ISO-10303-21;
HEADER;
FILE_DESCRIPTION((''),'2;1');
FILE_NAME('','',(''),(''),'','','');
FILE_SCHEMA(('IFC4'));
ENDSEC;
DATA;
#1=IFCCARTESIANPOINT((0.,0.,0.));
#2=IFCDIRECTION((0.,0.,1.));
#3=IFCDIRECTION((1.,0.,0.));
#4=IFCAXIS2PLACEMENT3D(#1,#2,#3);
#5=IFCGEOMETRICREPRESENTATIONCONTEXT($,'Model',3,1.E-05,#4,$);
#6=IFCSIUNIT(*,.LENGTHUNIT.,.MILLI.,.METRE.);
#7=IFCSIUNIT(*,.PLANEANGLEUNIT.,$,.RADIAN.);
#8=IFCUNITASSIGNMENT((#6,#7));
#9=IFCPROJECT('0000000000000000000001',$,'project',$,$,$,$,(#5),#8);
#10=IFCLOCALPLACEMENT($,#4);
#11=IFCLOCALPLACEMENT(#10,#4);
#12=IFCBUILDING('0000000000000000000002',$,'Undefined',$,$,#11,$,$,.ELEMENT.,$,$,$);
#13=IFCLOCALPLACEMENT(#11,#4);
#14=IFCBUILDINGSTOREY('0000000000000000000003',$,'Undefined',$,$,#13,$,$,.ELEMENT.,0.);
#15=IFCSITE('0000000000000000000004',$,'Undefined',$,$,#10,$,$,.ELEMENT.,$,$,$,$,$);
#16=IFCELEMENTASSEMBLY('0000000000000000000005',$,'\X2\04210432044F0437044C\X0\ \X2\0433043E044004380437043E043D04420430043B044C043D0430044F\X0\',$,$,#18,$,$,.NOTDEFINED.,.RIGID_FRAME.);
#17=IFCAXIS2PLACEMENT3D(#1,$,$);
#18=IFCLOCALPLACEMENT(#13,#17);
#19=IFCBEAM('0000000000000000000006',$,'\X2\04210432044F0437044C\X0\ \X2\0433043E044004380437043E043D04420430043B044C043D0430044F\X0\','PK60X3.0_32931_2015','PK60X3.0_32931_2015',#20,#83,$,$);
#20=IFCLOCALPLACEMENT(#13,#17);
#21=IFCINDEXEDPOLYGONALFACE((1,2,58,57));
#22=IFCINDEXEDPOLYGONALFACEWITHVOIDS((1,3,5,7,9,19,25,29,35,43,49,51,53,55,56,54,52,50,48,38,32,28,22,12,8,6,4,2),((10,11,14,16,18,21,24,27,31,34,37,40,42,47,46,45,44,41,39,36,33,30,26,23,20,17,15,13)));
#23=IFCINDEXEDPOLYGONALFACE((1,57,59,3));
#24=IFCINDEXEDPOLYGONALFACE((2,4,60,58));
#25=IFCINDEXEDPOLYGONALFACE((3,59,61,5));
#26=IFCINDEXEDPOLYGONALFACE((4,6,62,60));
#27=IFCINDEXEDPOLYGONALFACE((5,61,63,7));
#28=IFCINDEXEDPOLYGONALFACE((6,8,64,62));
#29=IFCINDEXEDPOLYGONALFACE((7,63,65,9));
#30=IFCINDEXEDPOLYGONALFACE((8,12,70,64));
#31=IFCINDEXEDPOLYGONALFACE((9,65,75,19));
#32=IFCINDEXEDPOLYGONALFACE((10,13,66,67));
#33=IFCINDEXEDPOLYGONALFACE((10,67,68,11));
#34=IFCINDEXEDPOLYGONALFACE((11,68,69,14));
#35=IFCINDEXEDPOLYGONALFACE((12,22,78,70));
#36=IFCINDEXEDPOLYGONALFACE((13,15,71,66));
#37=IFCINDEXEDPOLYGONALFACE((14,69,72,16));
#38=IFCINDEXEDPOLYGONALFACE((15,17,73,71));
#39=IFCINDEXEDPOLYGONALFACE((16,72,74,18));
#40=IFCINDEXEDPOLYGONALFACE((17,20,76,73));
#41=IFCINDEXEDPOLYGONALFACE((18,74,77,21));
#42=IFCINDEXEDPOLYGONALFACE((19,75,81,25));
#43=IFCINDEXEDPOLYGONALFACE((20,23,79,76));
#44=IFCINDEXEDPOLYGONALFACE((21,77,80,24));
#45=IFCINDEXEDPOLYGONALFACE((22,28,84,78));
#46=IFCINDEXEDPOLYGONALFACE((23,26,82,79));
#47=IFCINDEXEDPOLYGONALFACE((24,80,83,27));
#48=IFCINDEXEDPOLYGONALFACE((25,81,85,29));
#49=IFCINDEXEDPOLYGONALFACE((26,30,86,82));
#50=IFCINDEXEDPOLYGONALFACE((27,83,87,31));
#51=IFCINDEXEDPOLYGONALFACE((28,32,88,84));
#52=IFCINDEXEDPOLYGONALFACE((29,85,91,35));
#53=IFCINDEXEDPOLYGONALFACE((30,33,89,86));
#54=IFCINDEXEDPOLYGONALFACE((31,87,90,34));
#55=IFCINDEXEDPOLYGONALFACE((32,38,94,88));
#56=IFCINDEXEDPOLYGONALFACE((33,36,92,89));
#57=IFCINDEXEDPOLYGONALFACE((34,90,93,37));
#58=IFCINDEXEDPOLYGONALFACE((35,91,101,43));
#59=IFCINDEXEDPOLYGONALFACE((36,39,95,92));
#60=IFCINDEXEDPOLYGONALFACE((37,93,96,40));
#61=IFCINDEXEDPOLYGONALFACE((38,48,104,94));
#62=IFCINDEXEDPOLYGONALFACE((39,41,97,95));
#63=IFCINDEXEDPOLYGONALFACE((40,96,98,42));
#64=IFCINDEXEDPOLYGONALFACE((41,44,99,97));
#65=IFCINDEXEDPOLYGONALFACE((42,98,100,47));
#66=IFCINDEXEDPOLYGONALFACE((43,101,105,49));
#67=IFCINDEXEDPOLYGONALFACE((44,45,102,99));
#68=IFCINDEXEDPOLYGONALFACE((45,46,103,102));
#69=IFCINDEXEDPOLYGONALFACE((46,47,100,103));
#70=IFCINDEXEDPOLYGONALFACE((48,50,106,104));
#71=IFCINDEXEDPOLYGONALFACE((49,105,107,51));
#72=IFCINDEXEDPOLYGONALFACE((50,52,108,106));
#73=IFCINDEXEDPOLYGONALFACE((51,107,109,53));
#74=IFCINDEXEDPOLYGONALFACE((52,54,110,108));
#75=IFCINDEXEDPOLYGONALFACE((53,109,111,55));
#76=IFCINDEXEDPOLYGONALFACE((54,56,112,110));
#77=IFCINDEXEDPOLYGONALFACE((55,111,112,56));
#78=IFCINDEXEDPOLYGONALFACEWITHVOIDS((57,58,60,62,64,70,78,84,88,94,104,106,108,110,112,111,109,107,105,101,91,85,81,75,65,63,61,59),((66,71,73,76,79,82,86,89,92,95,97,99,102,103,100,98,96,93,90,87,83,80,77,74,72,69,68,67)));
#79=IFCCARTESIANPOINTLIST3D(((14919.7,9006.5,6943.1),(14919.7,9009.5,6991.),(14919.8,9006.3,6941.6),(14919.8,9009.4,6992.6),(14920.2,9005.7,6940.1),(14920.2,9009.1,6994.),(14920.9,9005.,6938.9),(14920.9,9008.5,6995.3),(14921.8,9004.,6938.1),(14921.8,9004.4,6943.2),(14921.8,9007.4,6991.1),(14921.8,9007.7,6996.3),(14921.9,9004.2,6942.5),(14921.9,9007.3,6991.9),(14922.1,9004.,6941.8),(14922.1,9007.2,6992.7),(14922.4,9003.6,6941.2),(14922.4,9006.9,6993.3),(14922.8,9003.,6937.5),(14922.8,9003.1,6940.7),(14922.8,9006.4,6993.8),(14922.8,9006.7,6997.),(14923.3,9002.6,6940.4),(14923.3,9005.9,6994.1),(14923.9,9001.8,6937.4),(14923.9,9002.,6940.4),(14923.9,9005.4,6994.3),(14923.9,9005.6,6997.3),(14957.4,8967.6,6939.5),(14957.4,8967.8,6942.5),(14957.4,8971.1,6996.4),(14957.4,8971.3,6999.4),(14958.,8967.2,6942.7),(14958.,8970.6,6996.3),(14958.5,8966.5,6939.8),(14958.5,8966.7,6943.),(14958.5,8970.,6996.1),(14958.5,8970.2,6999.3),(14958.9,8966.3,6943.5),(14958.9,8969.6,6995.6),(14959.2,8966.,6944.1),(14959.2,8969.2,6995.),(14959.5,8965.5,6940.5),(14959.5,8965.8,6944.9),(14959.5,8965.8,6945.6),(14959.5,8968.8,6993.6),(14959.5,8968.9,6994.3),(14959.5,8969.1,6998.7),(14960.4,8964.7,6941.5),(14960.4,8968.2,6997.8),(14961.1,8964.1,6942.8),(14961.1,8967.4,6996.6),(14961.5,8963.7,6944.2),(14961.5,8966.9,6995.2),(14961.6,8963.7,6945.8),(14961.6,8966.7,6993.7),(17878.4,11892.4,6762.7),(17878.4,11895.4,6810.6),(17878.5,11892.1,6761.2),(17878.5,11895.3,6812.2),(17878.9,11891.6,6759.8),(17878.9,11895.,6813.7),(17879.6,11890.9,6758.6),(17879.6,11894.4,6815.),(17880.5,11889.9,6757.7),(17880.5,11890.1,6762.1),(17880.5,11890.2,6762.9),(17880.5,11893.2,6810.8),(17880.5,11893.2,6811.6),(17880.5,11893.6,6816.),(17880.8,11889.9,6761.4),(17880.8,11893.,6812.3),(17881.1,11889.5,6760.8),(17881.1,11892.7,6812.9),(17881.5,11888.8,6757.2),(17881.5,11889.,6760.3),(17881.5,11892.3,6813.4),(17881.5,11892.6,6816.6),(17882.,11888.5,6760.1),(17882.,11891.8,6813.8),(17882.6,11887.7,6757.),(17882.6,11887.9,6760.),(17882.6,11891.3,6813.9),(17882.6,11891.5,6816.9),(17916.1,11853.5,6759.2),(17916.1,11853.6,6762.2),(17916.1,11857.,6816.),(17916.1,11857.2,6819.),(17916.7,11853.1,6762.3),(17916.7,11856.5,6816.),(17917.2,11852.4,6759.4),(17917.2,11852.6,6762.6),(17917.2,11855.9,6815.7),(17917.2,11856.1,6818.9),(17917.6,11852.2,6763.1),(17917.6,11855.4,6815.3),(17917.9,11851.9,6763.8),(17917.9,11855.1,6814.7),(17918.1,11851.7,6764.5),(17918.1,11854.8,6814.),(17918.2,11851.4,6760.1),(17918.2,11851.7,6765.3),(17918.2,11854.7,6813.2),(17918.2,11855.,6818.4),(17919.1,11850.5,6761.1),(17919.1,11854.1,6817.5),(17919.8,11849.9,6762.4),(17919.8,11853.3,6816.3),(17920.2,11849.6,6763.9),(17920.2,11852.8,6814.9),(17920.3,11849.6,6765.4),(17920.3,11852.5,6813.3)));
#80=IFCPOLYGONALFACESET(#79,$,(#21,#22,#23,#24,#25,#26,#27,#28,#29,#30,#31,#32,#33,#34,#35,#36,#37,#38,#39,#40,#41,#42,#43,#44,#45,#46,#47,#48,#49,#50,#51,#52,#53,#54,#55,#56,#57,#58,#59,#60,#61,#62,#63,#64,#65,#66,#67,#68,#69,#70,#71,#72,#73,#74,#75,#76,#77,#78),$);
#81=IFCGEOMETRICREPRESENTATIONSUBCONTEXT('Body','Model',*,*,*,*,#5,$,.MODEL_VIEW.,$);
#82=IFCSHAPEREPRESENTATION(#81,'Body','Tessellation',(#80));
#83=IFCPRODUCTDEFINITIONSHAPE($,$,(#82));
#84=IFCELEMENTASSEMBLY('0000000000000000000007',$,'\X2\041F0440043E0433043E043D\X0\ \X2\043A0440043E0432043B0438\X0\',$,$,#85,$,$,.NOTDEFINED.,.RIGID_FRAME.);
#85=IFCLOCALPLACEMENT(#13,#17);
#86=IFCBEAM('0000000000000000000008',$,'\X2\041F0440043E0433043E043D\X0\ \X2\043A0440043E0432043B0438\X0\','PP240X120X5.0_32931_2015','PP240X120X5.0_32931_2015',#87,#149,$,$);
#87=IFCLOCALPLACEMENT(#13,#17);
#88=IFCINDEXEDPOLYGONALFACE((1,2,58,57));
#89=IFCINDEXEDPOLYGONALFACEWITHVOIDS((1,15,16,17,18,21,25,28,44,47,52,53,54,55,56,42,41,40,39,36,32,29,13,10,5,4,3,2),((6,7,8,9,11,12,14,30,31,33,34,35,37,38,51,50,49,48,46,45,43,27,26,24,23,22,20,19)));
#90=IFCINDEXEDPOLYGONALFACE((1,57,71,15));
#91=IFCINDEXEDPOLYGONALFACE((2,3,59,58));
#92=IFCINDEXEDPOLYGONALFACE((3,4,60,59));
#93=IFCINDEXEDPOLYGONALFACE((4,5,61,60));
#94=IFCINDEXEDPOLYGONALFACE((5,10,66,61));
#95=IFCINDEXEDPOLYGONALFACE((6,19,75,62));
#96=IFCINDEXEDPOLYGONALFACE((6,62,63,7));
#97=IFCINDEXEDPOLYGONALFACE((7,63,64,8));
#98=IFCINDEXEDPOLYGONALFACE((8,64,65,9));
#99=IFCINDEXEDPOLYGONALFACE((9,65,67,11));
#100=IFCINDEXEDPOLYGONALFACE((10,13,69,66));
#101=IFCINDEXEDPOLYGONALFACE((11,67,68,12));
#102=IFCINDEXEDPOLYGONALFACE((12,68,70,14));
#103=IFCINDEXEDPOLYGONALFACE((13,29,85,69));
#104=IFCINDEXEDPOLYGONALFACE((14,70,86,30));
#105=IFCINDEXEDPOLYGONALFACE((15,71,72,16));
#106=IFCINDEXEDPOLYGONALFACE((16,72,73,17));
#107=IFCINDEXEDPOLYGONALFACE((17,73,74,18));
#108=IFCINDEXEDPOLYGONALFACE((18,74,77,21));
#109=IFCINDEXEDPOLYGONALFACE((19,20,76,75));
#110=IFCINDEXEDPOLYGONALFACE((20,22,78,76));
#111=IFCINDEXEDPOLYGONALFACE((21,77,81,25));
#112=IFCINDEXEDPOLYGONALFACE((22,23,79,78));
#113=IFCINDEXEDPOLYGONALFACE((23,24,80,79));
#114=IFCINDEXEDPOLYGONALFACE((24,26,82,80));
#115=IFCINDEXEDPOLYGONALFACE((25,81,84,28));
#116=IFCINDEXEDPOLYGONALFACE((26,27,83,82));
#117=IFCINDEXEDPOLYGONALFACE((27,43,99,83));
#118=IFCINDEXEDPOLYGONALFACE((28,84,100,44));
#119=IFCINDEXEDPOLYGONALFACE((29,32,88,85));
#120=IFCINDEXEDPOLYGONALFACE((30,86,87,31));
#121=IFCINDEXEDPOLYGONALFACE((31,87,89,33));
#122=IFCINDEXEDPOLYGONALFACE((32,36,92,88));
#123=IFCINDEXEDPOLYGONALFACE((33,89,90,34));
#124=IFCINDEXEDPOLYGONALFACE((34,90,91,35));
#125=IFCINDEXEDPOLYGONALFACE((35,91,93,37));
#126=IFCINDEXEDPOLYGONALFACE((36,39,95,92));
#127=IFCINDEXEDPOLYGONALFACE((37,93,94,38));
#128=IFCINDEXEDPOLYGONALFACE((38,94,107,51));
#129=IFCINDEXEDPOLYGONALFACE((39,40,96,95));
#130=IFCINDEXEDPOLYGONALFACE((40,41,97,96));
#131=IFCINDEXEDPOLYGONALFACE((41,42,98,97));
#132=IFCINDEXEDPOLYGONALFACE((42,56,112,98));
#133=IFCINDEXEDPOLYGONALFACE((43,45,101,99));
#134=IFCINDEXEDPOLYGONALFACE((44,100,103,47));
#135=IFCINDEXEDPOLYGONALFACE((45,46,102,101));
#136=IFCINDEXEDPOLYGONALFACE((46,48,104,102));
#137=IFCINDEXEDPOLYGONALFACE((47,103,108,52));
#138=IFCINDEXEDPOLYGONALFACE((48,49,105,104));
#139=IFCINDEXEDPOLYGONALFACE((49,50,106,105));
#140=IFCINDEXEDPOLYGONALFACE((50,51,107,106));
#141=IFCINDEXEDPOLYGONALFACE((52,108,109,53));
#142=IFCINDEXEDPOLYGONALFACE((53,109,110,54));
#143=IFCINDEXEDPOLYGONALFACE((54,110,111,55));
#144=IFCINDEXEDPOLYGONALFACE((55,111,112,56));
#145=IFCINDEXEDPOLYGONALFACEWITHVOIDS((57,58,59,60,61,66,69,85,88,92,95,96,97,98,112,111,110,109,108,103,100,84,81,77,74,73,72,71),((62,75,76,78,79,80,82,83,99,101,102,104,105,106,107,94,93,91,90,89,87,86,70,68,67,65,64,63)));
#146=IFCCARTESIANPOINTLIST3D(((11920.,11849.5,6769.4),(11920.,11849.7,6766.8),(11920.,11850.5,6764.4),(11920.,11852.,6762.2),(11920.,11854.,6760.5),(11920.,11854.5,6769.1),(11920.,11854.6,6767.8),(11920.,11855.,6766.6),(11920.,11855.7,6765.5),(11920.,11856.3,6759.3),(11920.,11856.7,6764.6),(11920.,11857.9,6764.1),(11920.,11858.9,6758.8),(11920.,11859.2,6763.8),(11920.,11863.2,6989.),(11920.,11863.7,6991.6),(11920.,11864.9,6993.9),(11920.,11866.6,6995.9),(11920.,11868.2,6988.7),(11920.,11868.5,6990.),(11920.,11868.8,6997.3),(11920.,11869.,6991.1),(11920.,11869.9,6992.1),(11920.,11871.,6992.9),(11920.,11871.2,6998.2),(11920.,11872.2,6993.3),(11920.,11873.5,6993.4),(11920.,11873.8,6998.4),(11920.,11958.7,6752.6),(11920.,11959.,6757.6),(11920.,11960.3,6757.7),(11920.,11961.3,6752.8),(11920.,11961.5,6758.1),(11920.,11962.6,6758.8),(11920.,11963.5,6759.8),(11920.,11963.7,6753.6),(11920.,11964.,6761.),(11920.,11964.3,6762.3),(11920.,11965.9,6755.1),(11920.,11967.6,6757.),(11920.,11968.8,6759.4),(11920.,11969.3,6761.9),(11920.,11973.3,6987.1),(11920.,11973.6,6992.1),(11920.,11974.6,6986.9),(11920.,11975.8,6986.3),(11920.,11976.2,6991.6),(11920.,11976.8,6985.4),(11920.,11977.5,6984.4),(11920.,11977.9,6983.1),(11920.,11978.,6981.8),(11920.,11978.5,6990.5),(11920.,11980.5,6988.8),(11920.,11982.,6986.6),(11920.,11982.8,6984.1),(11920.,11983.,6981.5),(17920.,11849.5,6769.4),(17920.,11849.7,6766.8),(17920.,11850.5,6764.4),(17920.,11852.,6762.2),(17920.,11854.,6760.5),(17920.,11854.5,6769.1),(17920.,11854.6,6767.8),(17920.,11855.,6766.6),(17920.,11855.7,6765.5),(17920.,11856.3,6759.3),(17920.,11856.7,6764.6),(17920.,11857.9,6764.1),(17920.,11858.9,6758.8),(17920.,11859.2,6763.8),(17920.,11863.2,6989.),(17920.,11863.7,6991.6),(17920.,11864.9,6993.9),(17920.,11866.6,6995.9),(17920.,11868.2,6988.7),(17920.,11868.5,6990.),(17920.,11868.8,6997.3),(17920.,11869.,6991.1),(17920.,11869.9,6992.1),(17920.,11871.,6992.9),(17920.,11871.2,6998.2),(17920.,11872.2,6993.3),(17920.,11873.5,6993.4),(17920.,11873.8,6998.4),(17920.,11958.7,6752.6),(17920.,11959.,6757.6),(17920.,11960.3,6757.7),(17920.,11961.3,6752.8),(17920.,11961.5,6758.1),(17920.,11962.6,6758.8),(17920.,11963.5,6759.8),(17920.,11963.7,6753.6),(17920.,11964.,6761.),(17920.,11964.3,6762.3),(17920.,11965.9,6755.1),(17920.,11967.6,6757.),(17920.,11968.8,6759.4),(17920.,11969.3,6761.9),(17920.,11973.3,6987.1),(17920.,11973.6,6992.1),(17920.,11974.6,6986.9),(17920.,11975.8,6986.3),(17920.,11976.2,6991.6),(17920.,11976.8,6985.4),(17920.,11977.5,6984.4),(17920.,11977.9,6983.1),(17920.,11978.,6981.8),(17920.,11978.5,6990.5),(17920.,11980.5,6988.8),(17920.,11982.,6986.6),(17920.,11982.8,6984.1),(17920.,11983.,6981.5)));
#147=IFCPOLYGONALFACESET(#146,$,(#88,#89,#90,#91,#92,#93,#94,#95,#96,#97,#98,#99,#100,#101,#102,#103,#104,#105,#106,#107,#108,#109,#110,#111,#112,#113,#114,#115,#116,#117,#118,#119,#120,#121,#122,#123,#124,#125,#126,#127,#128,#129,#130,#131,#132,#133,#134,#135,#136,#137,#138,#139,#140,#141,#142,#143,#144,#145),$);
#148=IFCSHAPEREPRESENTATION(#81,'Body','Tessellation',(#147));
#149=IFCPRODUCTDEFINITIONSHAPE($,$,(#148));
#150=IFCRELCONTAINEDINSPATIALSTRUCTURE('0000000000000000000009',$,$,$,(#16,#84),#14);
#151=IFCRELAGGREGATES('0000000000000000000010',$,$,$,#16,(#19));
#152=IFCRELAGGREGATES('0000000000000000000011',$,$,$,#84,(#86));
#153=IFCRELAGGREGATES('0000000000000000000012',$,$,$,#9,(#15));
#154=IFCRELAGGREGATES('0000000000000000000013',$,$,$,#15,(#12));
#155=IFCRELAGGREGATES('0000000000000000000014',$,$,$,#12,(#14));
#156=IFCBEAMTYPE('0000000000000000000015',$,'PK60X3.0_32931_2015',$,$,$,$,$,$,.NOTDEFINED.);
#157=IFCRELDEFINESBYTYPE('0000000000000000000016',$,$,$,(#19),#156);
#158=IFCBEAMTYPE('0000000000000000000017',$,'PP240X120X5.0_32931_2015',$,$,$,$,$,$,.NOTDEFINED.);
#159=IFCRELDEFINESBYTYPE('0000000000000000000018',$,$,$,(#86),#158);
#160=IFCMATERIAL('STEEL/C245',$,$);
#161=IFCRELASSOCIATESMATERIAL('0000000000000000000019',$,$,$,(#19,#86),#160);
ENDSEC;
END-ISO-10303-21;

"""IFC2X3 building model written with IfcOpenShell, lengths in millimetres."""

from ifc_helpers import new_model, si_unit, frame, origin_with_axes, origin_2d_with_axis, place, context, subcontext, project, spatial, hollow_rectangle, extrude, material, type_object, element, aggregate, save


model = new_model("IFC2X3")

# Units and contexts
model_context = context("Model", 3, precision=1e-05, world=origin_with_axes())
body_context = subcontext(model_context, "Body", "Model", "MODEL_VIEW")
ifc_project = project(units=[si_unit("LENGTHUNIT", "METRE", prefix="MILLI"), si_unit("PLANEANGLEUNIT", "RADIAN")], contexts=[model_context])

# Site, building, storey
site_placement = place(None, origin_with_axes())
site = spatial("IfcSite", under=ifc_project, at=site_placement, Name="Undefined", CompositionType="ELEMENT")
building_placement = place(site_placement, origin_with_axes())
building = spatial("IfcBuilding", under=site, at=building_placement, Name="Undefined", CompositionType="ELEMENT")
storey_placement = place(building_placement, origin_with_axes())
storey = spatial("IfcBuildingStorey", under=building, at=storey_placement, Name="Undefined", CompositionType="ELEMENT", Elevation=0.0)

# Shared definitions
ifc_material = material(Name="STEEL/C245")

# Element assemblies, beams
beam_type_1 = type_object("IfcBeamType", Name="PK60X3.0_32931_2015", PredefinedType="NOTDEFINED")
assembly_1_placement = place(storey_placement, origin_with_axes())
assembly_1 = element("IfcElementAssembly", 1, at=assembly_1_placement, inside=storey, Name="Связь горизонтальная", AssemblyPlace="NOTDEFINED", PredefinedType="RIGID_FRAME")
beam_1_placement = place(assembly_1_placement, frame((17899.3, 11872.5, 6788.0), z_axis=(0.0, 0.062378, 0.998053), x_axis=(-0.715179, -0.69758, 0.043599)))
beam_1 = element("IfcBeam", 2, at=beam_1_placement, type_object=beam_type_1, material=ifc_material, Name="Связь горизонтальная", Description="PK60X3.0_32931_2015", ObjectType="PK60X3.0_32931_2015", context=body_context, shape_type="SweptSolid", body=[
    extrude(hollow_rectangle(XDim=60.0, YDim=60.0, WallThickness=3.0, InnerFilletRadius=3.0, OuterFilletRadius=6.0, at=origin_2d_with_axis()), frame((4137.0, 0.0, 0.0), z_axis=(-1.0, 0.0, 0.0), x_axis=(0.0, -1.0, 0.0)), (0.0, 0.0, 1.0), 4137.0),
])
aggregate(assembly_1, [beam_1])
assembly_2_placement = place(storey_placement, origin_with_axes())
assembly_2 = element("IfcElementAssembly", 3, at=assembly_2_placement, inside=storey, Name="Прогон кровли", AssemblyPlace="NOTDEFINED", PredefinedType="RIGID_FRAME")
beam_type_2 = type_object("IfcBeamType", Name="PP240X120X5.0_32931_2015", PredefinedType="NOTDEFINED")
beam_2_placement = place(assembly_2_placement, frame((17920.0, 11916.2, 6875.5), z_axis=(0.0, 0.062378, 0.998053), x_axis=(-1.0, 0.0, 0.0)))
beam_2 = element("IfcBeam", 4, at=beam_2_placement, type_object=beam_type_2, material=ifc_material, Name="Прогон кровли", Description="PP240X120X5.0_32931_2015", ObjectType="PP240X120X5.0_32931_2015", context=body_context, shape_type="SweptSolid", body=[
    extrude(hollow_rectangle(XDim=120.0, YDim=240.0, WallThickness=5.0, InnerFilletRadius=5.0, OuterFilletRadius=10.0, at=origin_2d_with_axis()), frame((6000.0, 0.0, 0.0), z_axis=(-1.0, 0.0, 0.0), x_axis=(0.0, -1.0, 0.0)), (0.0, 0.0, 1.0), 6000.0),
])
aggregate(assembly_2, [beam_2])

save(model, "model.ifc")
